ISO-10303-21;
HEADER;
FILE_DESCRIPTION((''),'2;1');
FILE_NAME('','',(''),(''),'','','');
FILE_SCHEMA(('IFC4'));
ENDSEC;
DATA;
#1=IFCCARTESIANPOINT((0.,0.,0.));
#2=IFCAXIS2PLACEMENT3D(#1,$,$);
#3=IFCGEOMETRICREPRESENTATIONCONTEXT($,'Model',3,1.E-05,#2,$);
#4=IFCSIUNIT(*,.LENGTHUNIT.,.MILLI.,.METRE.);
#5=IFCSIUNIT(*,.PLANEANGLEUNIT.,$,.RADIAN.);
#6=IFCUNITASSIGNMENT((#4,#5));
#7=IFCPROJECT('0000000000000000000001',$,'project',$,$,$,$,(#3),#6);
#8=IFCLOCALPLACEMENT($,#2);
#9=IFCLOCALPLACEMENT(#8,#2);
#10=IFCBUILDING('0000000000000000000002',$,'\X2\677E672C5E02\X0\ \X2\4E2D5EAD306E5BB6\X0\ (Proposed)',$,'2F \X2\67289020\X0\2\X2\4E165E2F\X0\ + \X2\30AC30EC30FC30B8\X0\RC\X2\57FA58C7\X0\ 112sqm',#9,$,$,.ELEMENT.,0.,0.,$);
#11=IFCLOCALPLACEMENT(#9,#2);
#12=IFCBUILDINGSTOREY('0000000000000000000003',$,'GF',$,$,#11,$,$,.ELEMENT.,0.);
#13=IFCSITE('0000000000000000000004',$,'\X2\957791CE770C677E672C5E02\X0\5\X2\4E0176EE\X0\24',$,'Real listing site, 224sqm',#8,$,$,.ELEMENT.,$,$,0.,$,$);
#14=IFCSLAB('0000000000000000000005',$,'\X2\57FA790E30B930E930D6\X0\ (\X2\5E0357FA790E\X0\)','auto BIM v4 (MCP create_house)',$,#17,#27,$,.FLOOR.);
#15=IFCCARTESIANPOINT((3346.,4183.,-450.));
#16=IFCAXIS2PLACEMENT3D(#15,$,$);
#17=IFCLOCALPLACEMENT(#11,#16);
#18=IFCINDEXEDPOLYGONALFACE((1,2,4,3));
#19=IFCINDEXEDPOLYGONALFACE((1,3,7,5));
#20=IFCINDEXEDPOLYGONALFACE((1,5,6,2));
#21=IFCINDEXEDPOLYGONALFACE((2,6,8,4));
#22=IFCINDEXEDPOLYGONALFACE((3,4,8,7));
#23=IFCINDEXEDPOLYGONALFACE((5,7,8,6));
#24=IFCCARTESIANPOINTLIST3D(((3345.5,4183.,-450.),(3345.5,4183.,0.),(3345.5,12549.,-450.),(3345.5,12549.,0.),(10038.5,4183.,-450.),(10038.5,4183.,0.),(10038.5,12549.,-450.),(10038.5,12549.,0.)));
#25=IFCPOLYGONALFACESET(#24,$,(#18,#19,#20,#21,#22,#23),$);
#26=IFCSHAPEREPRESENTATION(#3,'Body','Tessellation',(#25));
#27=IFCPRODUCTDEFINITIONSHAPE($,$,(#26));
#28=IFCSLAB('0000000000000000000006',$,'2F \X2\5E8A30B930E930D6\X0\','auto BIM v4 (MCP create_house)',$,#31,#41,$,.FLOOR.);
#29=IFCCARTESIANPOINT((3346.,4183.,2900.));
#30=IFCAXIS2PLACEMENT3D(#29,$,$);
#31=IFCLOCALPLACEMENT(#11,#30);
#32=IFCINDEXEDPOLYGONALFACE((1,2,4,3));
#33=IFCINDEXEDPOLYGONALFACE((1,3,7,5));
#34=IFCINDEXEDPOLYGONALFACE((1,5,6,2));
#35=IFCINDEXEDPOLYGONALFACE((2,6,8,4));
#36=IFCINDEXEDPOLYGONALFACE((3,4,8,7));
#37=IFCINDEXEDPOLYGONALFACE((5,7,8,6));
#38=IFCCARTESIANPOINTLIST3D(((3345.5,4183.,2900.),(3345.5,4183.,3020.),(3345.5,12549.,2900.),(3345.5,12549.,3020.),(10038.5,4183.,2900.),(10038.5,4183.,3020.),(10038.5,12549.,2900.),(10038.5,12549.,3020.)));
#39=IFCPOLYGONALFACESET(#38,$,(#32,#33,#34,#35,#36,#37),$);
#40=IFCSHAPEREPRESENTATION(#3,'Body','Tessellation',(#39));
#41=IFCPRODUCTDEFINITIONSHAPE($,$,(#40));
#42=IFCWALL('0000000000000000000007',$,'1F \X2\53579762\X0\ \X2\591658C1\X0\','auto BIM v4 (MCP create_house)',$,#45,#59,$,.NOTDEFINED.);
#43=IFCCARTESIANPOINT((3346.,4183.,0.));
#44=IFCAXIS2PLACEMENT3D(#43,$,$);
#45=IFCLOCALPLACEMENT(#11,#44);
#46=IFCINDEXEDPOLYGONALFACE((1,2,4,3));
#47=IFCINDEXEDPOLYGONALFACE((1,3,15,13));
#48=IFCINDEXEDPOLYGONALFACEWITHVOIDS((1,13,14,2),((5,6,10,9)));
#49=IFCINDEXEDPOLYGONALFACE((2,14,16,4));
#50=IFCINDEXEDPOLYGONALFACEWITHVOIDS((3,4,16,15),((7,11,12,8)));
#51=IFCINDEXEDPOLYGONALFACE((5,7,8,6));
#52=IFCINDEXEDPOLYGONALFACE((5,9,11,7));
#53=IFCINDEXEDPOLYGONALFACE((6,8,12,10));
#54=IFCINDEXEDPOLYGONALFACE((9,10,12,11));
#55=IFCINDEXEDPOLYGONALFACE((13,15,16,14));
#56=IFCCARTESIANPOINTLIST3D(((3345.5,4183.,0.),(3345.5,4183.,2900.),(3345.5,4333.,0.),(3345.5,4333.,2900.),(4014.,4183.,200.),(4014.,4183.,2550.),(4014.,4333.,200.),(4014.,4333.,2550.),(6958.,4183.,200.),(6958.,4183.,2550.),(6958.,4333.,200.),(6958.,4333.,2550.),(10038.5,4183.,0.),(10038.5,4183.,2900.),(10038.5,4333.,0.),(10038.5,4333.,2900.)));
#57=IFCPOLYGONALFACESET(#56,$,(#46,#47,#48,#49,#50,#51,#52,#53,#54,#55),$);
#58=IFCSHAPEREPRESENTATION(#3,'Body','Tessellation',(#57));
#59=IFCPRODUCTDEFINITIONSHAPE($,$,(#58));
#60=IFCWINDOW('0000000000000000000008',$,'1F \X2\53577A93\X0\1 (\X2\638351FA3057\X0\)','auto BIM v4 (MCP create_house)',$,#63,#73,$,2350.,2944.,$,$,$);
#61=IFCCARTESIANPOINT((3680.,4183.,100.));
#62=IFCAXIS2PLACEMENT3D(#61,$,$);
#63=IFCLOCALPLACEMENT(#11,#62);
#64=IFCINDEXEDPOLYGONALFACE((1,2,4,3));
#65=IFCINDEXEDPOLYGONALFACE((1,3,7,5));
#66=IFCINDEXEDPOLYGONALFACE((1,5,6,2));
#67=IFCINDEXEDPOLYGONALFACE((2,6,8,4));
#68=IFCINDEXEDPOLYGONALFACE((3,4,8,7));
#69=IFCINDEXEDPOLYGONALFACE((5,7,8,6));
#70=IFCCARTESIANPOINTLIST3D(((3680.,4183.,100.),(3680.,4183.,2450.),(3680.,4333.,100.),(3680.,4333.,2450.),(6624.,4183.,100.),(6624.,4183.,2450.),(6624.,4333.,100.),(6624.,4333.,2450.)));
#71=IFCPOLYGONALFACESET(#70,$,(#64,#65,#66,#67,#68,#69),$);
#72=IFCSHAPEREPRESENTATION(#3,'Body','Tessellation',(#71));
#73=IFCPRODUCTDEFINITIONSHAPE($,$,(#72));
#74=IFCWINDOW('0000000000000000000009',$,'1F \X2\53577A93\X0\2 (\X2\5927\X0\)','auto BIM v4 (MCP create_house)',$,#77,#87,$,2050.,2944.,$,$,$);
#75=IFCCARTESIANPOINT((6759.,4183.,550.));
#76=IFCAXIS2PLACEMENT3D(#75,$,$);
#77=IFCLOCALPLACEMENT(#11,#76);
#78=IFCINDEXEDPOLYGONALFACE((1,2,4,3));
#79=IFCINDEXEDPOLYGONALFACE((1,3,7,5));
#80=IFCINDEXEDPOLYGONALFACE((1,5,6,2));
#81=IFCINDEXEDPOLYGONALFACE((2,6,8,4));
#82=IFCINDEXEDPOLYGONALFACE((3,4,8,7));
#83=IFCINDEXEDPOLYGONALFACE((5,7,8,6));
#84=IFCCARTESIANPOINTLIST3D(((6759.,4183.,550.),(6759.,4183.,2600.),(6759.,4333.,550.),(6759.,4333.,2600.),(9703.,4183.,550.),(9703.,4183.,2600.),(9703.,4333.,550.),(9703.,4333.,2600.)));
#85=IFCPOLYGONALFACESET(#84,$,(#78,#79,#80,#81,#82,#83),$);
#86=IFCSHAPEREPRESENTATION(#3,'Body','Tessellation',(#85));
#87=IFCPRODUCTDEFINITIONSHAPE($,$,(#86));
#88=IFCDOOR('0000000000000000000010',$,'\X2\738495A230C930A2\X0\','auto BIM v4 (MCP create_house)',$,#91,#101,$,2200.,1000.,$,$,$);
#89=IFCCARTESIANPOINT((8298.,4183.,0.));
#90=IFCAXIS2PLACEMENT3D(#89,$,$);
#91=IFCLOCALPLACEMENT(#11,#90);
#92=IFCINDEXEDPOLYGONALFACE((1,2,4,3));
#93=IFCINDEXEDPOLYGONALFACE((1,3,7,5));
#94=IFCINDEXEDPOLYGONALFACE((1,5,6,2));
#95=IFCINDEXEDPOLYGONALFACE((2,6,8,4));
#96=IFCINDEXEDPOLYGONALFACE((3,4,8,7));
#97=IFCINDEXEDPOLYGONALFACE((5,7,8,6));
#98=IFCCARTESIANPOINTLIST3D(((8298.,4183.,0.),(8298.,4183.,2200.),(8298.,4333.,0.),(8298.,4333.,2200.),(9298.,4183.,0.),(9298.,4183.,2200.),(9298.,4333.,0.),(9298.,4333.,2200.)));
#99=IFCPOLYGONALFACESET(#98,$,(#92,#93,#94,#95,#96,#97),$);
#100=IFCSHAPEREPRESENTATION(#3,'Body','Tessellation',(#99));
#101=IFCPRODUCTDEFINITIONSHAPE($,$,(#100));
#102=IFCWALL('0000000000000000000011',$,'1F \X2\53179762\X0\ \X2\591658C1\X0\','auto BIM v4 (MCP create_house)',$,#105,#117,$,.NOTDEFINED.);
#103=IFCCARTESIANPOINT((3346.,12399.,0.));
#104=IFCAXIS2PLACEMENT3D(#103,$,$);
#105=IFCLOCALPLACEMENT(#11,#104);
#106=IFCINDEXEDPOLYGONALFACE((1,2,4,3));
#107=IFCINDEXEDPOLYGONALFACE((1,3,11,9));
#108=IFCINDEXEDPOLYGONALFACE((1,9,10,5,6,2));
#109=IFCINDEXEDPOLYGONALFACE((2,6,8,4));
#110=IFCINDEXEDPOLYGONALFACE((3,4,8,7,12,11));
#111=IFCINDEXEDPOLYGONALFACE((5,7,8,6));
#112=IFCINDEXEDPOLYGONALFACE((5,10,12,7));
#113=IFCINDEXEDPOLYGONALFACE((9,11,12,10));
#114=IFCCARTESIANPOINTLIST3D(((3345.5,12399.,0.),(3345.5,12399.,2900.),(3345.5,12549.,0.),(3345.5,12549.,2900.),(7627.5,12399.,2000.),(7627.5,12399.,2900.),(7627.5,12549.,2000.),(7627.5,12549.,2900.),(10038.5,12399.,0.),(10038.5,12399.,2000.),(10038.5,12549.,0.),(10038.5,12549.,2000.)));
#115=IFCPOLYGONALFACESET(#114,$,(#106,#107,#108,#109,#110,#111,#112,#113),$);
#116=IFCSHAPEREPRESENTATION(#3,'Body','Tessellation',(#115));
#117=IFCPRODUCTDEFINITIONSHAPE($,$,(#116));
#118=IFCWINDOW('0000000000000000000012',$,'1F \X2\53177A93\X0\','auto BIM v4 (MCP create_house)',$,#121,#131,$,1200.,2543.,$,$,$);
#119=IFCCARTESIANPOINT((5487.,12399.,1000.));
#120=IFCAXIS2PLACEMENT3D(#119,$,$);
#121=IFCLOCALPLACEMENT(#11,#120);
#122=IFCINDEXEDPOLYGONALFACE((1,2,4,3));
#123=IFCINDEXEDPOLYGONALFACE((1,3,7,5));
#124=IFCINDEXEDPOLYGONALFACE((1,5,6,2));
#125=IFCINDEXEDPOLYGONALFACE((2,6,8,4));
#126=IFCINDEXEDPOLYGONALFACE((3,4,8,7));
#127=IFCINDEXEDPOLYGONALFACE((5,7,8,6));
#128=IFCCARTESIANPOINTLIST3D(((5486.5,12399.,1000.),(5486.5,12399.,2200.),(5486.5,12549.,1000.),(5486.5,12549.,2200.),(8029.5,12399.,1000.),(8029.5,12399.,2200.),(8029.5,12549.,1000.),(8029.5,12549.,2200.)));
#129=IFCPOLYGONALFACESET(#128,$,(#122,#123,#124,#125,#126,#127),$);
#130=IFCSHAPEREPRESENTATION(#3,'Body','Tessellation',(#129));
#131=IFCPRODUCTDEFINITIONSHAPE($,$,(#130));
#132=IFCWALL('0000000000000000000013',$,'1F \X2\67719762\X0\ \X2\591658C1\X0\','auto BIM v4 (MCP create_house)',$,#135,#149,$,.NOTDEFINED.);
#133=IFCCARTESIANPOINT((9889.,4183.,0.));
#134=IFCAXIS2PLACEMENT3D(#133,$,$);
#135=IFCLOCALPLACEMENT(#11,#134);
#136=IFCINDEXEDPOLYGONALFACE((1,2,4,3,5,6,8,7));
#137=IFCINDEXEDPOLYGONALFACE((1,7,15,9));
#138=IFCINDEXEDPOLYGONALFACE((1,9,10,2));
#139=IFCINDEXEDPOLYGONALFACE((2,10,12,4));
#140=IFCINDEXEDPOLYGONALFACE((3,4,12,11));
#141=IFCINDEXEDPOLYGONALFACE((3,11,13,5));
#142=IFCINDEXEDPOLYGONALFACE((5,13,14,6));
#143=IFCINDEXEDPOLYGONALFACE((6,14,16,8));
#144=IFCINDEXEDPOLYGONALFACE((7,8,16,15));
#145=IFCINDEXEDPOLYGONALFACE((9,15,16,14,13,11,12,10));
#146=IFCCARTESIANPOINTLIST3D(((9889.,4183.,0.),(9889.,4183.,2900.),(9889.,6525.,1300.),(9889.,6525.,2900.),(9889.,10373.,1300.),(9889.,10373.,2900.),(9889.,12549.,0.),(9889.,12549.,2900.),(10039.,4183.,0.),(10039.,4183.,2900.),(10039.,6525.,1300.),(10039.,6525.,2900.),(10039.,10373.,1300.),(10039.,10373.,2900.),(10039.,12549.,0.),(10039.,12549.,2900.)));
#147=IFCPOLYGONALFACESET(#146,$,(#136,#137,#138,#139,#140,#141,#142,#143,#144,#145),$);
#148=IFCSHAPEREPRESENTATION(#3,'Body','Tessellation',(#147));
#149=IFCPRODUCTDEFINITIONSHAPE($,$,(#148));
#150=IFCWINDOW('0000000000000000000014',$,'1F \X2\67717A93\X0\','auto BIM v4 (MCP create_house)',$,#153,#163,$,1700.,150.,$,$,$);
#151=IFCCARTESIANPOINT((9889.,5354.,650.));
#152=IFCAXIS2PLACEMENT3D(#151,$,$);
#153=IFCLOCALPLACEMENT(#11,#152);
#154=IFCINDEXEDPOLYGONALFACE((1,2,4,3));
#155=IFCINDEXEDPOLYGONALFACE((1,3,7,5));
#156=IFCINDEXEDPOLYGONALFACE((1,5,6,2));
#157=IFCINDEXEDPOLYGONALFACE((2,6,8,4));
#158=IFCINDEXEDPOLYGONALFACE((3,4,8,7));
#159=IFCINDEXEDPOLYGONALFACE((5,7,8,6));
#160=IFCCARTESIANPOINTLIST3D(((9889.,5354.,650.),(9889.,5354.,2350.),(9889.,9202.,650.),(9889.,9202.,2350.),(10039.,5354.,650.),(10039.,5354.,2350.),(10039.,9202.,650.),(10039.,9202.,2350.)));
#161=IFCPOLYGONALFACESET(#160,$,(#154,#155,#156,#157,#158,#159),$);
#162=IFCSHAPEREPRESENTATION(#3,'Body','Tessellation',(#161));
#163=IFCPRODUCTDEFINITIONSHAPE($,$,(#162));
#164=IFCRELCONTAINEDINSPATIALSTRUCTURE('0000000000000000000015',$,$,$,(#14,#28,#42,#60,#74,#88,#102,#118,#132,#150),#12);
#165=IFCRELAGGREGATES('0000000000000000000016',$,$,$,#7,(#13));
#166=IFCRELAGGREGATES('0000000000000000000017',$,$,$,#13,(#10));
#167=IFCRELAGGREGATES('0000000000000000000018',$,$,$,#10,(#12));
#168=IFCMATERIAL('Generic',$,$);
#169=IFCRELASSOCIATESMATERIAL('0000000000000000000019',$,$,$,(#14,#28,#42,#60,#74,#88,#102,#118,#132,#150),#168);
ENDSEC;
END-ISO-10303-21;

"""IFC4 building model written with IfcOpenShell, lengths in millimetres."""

from ifc_helpers import new_model, si_unit, frame, frame_2d, origin, place, context, project, spatial, rectangle, extrude, material, element, fill, save


model = new_model("IFC4")

# Units and contexts
model_context = context("Model", 3, precision=1e-05, world=origin())
ifc_project = project(units=[si_unit("LENGTHUNIT", "METRE", prefix="MILLI"), si_unit("PLANEANGLEUNIT", "RADIAN")], contexts=[model_context])

# Site, building, storey
site_placement = place(None, origin())
site = spatial("IfcSite", under=ifc_project, at=site_placement, Name="長野県松本市5丁目24", ObjectType="Real listing site, 224sqm", CompositionType="ELEMENT", RefElevation=0.0)
building_placement = place(site_placement, origin())
building = spatial("IfcBuilding", under=site, at=building_placement, Name="松本市 中庭の家 (Proposed)", ObjectType="2F 木造2世帯 + ガレージRC基壇 112sqm", CompositionType="ELEMENT", ElevationOfRefHeight=0.0, ElevationOfTerrain=0.0)
storey_placement = place(building_placement, origin())
storey = spatial("IfcBuildingStorey", under=building, at=storey_placement, Name="GF", CompositionType="ELEMENT", Elevation=0.0)

# Slabs
ifc_material = material(Name="Generic")
slab_1_placement = place(storey_placement, frame((3346.0, 4183.0, -450.0)))
element("IfcSlab", 1, at=slab_1_placement, inside=storey, material=ifc_material, Name="基礎スラブ (布基礎)", Description="auto BIM v4 (MCP create_house)", PredefinedType="FLOOR", context=model_context, shape_type="SweptSolid", body=[
    extrude(rectangle(XDim=6693.0, YDim=8366.0, at=frame_2d((3346.0, 4183.0))), frame((3346.0, 4183.0, -450.0)), (0.0, 0.0, 1.0), 450.0),
])
slab_2_placement = place(storey_placement, frame((3346.0, 4183.0, 2900.0)))
element("IfcSlab", 2, at=slab_2_placement, inside=storey, material=ifc_material, Name="2F 床スラブ", Description="auto BIM v4 (MCP create_house)", PredefinedType="FLOOR", context=model_context, shape_type="SweptSolid", body=[
    extrude(rectangle(XDim=6693.0, YDim=8366.0, at=frame_2d((3346.0, 4183.0))), frame((3346.0, 4183.0, 2900.0)), (0.0, 0.0, 1.0), 120.0),
])

# Wall, openings, windows, door
wall_1_placement = place(storey_placement, frame((3346.0, 4183.0, 0.0)))
wall_1 = element("IfcWall", 3, at=wall_1_placement, inside=storey, material=ifc_material, Name="1F 南面 外壁", Description="auto BIM v4 (MCP create_house)", PredefinedType="NOTDEFINED", context=model_context, shape_type="SweptSolid", body=[
    extrude(rectangle(XDim=6693.0, YDim=150.0, at=frame_2d((3346.0, 75.0))), frame((3346.0, 4183.0, 0.0)), (0.0, 0.0, 1.0), 2900.0),
])
opening_1_placement = place(storey_placement, frame((3680.0, 4183.0, 100.0)))
opening_1 = element("IfcOpeningElement", 4, at=opening_1_placement, cuts=wall_1, PredefinedType="NOTDEFINED", context=model_context, shape_type="SweptSolid", body=[
    extrude(rectangle(XDim=2944.0, YDim=150.0, at=frame_2d((1472.0, 75.0))), frame((3680.0, 4183.0, 100.0)), (0.0, 0.0, 1.0), 2350.0),
])
opening_2_placement = place(storey_placement, frame((6759.0, 4183.0, 550.0)))
opening_2 = element("IfcOpeningElement", 5, at=opening_2_placement, cuts=wall_1, PredefinedType="NOTDEFINED", context=model_context, shape_type="SweptSolid", body=[
    extrude(rectangle(XDim=2944.0, YDim=150.0, at=frame_2d((1472.0, 75.0))), frame((6759.0, 4183.0, 550.0)), (0.0, 0.0, 1.0), 2050.0),
])
opening_3_placement = place(storey_placement, frame((8298.0, 4183.0, 0.0)))
opening_3 = element("IfcOpeningElement", 6, at=opening_3_placement, cuts=wall_1, PredefinedType="NOTDEFINED", context=model_context, shape_type="SweptSolid", body=[
    extrude(rectangle(XDim=1000.0, YDim=150.0, at=frame_2d((500.0, 75.0))), frame((8298.0, 4183.0, 0.0)), (0.0, 0.0, 1.0), 2200.0),
])
window_1_placement = place(storey_placement, frame((3680.0, 4183.0, 100.0)))
window_1 = element("IfcWindow", 7, at=window_1_placement, inside=storey, material=ifc_material, Name="1F 南窓1 (掃出し)", Description="auto BIM v4 (MCP create_house)", OverallHeight=2350.0, OverallWidth=2944.0, context=model_context, shape_type="SweptSolid", body=[
    extrude(rectangle(XDim=2944.0, YDim=150.0, at=frame_2d((1472.0, 75.0))), frame((3680.0, 4183.0, 100.0)), (0.0, 0.0, 1.0), 2350.0),
])
fill(opening_1, window_1)
window_2_placement = place(storey_placement, frame((6759.0, 4183.0, 550.0)))
window_2 = element("IfcWindow", 8, at=window_2_placement, inside=storey, material=ifc_material, Name="1F 南窓2 (大)", Description="auto BIM v4 (MCP create_house)", OverallHeight=2050.0, OverallWidth=2944.0, context=model_context, shape_type="SweptSolid", body=[
    extrude(rectangle(XDim=2944.0, YDim=150.0, at=frame_2d((1472.0, 75.0))), frame((6759.0, 4183.0, 550.0)), (0.0, 0.0, 1.0), 2050.0),
])
fill(opening_2, window_2)
door_1_placement = place(storey_placement, frame((8298.0, 4183.0, 0.0)))
door_1 = element("IfcDoor", 9, at=door_1_placement, inside=storey, material=ifc_material, Name="玄関ドア", Description="auto BIM v4 (MCP create_house)", OverallHeight=2200.0, OverallWidth=1000.0, context=model_context, shape_type="SweptSolid", body=[
    extrude(rectangle(XDim=1000.0, YDim=150.0, at=frame_2d((500.0, 75.0))), frame((8298.0, 4183.0, 0.0)), (0.0, 0.0, 1.0), 2200.0),
])
fill(opening_3, door_1)

# Walls, openings, windows
wall_2_placement = place(storey_placement, frame((3346.0, 12399.0, 0.0)))
wall_2 = element("IfcWall", 10, at=wall_2_placement, inside=storey, material=ifc_material, Name="1F 北面 外壁", Description="auto BIM v4 (MCP create_house)", PredefinedType="NOTDEFINED", context=model_context, shape_type="SweptSolid", body=[
    extrude(rectangle(XDim=6693.0, YDim=150.0, at=frame_2d((3346.0, 75.0))), frame((3346.0, 12399.0, 0.0)), (0.0, 0.0, 1.0), 2900.0),
])
opening_4_placement = place(storey_placement, frame((5487.0, 12399.0, 1000.0)))
opening_4 = element("IfcOpeningElement", 11, at=opening_4_placement, cuts=wall_2, PredefinedType="NOTDEFINED", context=model_context, shape_type="SweptSolid", body=[
    extrude(rectangle(XDim=2543.0, YDim=150.0, at=frame_2d((1271.0, 75.0))), frame((5487.0, 12399.0, 1000.0)), (0.0, 0.0, 1.0), 1200.0),
])
window_3_placement = place(storey_placement, frame((5487.0, 12399.0, 1000.0)))
window_3 = element("IfcWindow", 12, at=window_3_placement, inside=storey, material=ifc_material, Name="1F 北窓", Description="auto BIM v4 (MCP create_house)", OverallHeight=1200.0, OverallWidth=2543.0, context=model_context, shape_type="SweptSolid", body=[
    extrude(rectangle(XDim=2543.0, YDim=150.0, at=frame_2d((1271.0, 75.0))), frame((5487.0, 12399.0, 1000.0)), (0.0, 0.0, 1.0), 1200.0),
])
fill(opening_4, window_3)
wall_3_placement = place(storey_placement, frame((9889.0, 4183.0, 0.0)))
wall_3 = element("IfcWall", 13, at=wall_3_placement, inside=storey, material=ifc_material, Name="1F 東面 外壁", Description="auto BIM v4 (MCP create_house)", PredefinedType="NOTDEFINED", context=model_context, shape_type="SweptSolid", body=[
    extrude(rectangle(XDim=150.0, YDim=8366.0, at=frame_2d((75.0, 4183.0))), frame((9889.0, 4183.0, 0.0)), (0.0, 0.0, 1.0), 2900.0),
])
opening_5_placement = place(storey_placement, frame((9889.0, 5354.0, 650.0)))
opening_5 = element("IfcOpeningElement", 14, at=opening_5_placement, cuts=wall_3, PredefinedType="NOTDEFINED", context=model_context, shape_type="SweptSolid", body=[
    extrude(rectangle(XDim=150.0, YDim=3848.0, at=frame_2d((75.0, 1924.0))), frame((9889.0, 5354.0, 650.0)), (0.0, 0.0, 1.0), 1700.0),
])
window_4_placement = place(storey_placement, frame((9889.0, 5354.0, 650.0)))
window_4 = element("IfcWindow", 15, at=window_4_placement, inside=storey, material=ifc_material, Name="1F 東窓", Description="auto BIM v4 (MCP create_house)", OverallHeight=1700.0, OverallWidth=150.0, context=model_context, shape_type="SweptSolid", body=[
    extrude(rectangle(XDim=150.0, YDim=3848.0, at=frame_2d((75.0, 1924.0))), frame((9889.0, 5354.0, 650.0)), (0.0, 0.0, 1.0), 1700.0),
])
fill(opening_5, window_4)

save(model, "model.ifc")
